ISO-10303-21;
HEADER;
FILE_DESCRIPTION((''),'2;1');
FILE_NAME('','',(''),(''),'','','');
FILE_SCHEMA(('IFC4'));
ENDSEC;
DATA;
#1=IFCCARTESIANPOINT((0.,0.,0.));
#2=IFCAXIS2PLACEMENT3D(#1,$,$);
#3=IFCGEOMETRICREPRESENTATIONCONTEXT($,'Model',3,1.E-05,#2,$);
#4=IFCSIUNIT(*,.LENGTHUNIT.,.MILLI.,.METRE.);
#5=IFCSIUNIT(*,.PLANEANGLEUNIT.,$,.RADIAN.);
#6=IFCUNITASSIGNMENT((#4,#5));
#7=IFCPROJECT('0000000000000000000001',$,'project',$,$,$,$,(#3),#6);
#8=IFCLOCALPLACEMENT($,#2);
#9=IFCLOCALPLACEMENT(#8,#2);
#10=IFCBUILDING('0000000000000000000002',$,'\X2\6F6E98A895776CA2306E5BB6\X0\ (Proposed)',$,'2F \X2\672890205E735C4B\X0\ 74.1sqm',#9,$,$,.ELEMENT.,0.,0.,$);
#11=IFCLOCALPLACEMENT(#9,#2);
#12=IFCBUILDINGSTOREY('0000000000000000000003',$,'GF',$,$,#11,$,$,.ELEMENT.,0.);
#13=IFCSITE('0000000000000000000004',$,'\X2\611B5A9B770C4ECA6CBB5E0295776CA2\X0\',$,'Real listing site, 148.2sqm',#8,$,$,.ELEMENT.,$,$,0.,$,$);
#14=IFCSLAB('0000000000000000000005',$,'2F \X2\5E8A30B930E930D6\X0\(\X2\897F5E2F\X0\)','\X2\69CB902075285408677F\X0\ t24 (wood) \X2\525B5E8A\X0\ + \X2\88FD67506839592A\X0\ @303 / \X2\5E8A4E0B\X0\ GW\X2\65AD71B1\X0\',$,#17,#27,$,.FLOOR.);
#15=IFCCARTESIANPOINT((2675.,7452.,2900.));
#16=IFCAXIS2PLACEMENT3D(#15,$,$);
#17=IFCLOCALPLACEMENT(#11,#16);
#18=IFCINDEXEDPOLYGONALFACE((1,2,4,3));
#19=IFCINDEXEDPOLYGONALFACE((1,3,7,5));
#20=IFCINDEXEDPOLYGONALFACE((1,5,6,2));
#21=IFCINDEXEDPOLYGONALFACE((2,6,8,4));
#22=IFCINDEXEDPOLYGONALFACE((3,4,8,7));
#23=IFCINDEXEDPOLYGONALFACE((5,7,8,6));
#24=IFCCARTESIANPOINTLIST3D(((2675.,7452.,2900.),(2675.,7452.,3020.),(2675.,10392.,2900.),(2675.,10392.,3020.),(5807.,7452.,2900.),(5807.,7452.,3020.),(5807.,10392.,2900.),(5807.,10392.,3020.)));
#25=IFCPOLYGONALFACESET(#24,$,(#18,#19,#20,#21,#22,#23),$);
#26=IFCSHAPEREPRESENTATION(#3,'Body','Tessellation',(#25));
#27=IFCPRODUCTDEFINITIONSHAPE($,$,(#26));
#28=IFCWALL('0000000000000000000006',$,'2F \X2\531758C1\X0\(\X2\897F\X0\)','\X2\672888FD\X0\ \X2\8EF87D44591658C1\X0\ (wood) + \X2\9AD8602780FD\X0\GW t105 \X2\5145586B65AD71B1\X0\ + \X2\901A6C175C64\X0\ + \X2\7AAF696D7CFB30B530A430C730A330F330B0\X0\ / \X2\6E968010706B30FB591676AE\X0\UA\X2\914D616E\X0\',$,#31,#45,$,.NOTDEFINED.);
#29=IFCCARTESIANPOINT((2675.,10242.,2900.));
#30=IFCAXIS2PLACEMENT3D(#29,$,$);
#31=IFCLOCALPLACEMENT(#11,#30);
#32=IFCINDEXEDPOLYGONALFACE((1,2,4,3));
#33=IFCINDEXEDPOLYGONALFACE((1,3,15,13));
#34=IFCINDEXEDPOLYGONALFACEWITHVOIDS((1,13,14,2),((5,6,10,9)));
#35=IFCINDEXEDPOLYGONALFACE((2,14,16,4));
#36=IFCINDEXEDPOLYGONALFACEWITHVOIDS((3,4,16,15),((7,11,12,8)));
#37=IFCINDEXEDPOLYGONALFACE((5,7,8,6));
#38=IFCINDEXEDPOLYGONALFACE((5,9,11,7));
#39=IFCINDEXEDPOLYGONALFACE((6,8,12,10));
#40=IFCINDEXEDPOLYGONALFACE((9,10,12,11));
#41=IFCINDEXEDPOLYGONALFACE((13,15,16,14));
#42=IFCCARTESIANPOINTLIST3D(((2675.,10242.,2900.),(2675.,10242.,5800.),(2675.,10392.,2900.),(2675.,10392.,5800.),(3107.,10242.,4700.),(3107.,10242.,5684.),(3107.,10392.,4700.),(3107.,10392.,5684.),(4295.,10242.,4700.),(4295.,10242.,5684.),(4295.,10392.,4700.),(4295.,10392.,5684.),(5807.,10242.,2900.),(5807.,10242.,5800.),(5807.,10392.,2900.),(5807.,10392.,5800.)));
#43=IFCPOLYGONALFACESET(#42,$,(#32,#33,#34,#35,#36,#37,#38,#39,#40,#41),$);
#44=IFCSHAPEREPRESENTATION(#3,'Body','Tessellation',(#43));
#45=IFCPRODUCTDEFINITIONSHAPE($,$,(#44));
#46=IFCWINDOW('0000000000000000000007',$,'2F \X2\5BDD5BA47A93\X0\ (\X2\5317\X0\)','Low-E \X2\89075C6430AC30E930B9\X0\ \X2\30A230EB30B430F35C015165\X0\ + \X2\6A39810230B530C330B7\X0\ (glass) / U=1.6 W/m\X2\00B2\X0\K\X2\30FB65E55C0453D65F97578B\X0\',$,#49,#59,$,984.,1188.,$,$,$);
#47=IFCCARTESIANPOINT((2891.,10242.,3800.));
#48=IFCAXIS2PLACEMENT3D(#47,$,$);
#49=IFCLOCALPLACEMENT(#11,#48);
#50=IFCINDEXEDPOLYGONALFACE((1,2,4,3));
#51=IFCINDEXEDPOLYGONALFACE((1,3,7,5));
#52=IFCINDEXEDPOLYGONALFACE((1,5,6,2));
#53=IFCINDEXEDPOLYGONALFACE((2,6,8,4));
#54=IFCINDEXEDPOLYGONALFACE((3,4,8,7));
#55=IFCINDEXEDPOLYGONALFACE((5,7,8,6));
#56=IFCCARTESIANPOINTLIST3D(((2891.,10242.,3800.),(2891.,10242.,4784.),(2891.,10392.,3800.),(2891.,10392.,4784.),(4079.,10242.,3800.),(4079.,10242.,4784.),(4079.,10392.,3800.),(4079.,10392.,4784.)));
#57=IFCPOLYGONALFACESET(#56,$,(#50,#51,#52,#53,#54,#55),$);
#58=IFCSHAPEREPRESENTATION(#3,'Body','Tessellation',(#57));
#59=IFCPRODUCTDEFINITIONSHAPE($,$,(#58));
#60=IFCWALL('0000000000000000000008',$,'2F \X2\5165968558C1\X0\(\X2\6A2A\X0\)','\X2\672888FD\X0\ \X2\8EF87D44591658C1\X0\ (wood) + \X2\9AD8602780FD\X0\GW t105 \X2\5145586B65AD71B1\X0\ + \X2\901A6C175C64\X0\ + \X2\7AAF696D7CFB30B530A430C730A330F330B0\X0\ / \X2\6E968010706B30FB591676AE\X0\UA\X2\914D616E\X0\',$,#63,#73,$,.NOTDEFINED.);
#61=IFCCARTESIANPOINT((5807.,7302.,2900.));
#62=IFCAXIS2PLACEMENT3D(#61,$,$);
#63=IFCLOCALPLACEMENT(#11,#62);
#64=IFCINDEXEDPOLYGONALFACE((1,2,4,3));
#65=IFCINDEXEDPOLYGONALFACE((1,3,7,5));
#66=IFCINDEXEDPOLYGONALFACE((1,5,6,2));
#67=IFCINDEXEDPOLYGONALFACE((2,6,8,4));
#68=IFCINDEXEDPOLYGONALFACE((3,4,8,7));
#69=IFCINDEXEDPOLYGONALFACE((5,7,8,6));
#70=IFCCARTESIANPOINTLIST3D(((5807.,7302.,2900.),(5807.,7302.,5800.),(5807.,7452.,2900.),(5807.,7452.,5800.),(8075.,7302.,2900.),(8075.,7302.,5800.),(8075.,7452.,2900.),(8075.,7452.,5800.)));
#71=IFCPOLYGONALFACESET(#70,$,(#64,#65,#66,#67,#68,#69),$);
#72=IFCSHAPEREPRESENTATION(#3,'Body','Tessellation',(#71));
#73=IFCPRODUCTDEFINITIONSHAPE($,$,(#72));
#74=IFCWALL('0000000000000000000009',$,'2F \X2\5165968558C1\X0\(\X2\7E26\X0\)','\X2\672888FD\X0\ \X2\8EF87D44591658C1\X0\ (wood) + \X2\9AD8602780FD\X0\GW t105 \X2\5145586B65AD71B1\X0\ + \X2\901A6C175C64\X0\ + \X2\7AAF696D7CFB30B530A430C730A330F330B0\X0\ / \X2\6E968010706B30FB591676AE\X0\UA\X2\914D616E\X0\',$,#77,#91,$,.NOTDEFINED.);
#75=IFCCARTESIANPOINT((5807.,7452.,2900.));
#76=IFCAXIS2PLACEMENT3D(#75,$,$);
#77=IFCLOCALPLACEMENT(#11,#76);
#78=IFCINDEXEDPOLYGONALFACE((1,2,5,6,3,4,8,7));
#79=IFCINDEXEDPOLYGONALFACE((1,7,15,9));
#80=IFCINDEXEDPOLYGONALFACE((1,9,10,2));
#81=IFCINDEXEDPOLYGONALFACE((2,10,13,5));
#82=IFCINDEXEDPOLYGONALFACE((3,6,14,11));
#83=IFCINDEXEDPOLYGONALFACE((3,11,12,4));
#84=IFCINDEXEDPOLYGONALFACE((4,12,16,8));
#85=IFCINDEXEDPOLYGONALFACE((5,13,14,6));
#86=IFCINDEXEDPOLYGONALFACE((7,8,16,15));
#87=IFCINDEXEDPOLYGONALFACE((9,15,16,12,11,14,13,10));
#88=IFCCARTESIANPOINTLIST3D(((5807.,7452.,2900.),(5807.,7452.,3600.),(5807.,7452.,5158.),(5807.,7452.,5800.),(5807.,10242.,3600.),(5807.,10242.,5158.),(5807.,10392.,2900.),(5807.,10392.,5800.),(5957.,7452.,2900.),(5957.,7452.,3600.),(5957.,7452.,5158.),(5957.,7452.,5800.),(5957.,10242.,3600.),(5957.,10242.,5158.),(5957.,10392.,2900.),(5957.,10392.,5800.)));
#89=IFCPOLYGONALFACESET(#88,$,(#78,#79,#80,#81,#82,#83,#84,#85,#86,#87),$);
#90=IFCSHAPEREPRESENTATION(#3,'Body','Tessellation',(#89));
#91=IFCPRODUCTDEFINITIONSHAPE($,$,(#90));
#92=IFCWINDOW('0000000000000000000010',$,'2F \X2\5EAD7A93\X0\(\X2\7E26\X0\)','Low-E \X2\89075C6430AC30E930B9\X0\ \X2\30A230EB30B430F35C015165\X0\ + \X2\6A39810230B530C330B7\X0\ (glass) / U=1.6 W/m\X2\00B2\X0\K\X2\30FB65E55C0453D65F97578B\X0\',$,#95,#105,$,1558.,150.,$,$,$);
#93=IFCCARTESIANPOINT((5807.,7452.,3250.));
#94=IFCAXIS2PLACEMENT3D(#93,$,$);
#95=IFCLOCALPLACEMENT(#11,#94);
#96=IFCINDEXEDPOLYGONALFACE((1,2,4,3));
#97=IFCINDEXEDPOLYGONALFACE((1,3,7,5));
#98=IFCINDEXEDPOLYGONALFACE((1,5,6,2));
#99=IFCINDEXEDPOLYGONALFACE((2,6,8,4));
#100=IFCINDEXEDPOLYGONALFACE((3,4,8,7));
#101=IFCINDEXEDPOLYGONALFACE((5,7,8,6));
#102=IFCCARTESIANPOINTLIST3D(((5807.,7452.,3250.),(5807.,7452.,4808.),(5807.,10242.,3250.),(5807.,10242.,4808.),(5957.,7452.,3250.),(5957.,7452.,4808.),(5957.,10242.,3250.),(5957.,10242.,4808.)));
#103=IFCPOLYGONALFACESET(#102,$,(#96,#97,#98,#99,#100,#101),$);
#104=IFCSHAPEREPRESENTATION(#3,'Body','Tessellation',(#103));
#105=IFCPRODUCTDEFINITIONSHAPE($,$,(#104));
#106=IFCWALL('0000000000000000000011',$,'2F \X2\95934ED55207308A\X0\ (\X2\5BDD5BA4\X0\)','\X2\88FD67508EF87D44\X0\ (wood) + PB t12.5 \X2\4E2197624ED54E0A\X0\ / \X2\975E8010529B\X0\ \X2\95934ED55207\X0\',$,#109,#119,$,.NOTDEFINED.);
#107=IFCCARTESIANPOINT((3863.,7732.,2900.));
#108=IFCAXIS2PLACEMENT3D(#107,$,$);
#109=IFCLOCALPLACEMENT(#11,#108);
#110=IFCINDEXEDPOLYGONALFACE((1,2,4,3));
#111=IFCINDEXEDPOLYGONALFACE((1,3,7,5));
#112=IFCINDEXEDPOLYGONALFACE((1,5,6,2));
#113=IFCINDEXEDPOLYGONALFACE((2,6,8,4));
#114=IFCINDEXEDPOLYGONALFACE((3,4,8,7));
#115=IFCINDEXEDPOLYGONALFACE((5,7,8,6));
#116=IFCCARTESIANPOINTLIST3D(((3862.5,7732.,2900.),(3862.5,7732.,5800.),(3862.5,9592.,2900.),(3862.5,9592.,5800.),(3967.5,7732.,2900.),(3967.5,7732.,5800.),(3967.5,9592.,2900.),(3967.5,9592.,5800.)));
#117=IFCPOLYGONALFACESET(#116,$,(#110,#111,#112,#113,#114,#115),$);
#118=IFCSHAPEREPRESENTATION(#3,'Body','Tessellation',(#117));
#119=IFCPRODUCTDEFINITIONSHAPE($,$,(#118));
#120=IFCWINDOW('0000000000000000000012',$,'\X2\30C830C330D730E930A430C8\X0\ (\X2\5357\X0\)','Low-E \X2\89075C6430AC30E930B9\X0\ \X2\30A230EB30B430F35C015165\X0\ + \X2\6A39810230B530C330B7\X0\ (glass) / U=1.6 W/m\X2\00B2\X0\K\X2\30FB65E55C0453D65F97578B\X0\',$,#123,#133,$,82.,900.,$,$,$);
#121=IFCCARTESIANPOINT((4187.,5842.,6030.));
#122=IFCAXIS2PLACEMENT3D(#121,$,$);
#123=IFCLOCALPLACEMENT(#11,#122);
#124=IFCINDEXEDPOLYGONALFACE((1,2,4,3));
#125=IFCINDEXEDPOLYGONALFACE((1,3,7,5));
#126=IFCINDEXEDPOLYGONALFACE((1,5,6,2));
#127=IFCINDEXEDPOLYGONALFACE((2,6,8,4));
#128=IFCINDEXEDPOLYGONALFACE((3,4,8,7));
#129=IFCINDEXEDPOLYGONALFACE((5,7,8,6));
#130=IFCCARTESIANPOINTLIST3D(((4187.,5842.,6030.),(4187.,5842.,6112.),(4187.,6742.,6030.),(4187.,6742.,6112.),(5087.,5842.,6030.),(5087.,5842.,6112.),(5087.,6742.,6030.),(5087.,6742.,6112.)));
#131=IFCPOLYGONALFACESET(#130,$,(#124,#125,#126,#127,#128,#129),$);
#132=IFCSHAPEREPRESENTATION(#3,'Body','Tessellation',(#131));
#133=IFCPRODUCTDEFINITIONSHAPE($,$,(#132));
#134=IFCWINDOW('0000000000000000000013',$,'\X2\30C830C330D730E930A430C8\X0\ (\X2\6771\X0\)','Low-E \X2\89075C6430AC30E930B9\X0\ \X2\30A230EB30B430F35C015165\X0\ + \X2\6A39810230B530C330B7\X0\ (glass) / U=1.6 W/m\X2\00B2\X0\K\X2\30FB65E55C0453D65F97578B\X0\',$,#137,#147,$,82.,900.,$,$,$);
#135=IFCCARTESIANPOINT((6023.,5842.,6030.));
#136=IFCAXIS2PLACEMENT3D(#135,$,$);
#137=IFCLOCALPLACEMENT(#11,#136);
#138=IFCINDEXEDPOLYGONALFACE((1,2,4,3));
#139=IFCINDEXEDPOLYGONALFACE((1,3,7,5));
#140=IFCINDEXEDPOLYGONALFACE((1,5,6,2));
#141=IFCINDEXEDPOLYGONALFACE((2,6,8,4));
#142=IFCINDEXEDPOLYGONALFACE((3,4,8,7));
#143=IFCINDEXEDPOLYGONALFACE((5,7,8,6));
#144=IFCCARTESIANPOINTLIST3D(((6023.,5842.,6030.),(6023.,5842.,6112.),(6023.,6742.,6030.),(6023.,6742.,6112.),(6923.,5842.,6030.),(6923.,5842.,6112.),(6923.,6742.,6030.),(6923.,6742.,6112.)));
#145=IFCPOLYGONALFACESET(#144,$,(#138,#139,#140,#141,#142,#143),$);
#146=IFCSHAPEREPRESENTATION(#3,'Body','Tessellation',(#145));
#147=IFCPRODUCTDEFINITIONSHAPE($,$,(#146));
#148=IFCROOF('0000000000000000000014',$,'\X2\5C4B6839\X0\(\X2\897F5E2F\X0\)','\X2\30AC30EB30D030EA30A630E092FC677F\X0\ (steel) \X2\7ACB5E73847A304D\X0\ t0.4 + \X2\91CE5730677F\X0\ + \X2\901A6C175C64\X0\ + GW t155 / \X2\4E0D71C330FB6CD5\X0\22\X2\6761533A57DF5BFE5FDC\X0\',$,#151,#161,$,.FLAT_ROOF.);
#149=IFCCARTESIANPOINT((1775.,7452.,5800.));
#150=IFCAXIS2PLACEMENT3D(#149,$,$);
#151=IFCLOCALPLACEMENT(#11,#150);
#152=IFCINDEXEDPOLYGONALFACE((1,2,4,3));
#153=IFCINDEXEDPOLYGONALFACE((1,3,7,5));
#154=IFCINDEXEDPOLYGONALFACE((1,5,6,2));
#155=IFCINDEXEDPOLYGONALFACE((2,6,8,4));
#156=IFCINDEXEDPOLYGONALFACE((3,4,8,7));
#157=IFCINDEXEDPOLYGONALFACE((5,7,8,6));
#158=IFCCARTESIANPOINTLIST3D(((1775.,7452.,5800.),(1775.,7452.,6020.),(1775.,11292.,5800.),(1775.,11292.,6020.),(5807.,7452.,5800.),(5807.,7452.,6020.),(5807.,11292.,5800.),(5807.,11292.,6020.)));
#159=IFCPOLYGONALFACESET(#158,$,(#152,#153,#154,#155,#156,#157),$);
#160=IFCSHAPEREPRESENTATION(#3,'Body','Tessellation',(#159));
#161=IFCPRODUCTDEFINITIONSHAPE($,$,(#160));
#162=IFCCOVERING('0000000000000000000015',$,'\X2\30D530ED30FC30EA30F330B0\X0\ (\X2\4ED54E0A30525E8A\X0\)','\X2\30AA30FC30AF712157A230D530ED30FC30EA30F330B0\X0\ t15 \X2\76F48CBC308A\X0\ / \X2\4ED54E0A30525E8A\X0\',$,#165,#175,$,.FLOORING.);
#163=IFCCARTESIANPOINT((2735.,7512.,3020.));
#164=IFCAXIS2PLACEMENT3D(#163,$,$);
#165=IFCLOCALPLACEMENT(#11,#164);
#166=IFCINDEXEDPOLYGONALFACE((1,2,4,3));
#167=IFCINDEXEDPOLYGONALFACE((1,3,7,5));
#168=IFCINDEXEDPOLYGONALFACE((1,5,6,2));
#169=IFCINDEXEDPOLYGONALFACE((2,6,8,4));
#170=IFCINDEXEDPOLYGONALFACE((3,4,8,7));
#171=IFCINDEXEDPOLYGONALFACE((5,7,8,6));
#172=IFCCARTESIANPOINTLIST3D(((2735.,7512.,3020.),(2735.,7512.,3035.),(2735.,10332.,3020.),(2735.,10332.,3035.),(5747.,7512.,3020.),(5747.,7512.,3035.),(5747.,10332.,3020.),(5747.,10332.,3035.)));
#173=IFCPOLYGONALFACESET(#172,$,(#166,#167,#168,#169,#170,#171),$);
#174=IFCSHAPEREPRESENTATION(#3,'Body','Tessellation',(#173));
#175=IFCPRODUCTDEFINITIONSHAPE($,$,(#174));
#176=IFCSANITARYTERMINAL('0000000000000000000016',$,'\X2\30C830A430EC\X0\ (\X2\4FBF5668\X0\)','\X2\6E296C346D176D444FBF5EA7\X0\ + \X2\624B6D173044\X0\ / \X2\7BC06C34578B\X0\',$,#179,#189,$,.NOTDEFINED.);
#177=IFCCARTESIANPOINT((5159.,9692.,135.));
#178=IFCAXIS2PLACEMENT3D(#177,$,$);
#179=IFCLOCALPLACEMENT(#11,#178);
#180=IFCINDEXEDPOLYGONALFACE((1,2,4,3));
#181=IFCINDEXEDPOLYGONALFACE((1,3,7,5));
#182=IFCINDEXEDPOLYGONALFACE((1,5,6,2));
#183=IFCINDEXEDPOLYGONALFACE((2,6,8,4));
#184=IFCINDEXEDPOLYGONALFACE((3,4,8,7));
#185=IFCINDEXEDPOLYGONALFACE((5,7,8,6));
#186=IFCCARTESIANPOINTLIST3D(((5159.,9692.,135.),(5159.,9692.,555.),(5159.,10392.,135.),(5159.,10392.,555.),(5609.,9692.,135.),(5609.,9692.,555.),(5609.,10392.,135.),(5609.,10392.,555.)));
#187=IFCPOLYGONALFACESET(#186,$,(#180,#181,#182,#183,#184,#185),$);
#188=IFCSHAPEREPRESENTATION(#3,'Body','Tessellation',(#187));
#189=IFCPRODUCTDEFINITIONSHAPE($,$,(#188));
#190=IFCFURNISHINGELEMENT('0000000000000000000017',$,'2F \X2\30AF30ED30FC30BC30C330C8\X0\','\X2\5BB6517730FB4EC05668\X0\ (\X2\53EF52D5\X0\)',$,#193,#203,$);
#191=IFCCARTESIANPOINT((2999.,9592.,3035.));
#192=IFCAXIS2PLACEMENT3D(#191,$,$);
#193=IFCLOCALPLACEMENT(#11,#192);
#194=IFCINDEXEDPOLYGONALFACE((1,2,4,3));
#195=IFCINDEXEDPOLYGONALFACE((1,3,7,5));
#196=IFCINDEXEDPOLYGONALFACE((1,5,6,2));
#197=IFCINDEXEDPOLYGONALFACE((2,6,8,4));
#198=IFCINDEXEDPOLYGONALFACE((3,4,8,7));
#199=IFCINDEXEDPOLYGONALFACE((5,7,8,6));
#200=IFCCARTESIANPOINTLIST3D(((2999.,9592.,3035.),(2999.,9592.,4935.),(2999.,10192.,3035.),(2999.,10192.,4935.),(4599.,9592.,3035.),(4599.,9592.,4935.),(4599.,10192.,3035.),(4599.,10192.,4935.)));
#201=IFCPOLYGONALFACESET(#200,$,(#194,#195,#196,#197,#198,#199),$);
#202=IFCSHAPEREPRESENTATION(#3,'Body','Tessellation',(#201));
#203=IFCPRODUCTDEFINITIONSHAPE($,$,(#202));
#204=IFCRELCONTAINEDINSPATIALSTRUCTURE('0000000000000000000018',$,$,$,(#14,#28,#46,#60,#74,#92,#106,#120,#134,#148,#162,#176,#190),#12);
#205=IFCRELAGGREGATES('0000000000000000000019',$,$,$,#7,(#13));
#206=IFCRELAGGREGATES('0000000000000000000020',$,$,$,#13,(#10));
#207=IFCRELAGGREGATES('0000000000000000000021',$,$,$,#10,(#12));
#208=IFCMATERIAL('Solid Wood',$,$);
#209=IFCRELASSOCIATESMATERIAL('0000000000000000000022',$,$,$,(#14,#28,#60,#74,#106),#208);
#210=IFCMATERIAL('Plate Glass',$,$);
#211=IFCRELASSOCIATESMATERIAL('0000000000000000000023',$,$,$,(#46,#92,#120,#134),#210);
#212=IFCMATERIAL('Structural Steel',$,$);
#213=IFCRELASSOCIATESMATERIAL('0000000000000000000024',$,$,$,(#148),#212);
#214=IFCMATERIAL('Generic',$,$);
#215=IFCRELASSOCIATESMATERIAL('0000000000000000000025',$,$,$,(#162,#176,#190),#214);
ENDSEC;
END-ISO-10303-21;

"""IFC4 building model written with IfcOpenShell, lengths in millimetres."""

from ifc_helpers import new_model, si_unit, frame, frame_2d, origin, place, context, project, spatial, rectangle, extrude, material, element, fill, save


model = new_model("IFC4")

# Units and contexts
model_context = context("Model", 3, precision=1e-05, world=origin())
ifc_project = project(units=[si_unit("LENGTHUNIT", "METRE", prefix="MILLI"), si_unit("PLANEANGLEUNIT", "RADIAN")], contexts=[model_context])

# Site, building, storey
site_placement = place(None, origin())
site = spatial("IfcSite", under=ifc_project, at=site_placement, Name="愛媛県今治市長沢", ObjectType="Real listing site, 148.2sqm", CompositionType="ELEMENT", RefElevation=0.0)
building_placement = place(site_placement, origin())
building = spatial("IfcBuilding", under=site, at=building_placement, Name="潮風長沢の家 (Proposed)", ObjectType="2F 木造平屋 74.1sqm", CompositionType="ELEMENT", ElevationOfRefHeight=0.0, ElevationOfTerrain=0.0)
storey_placement = place(building_placement, origin())
storey = spatial("IfcBuildingStorey", under=building, at=storey_placement, Name="GF", CompositionType="ELEMENT", Elevation=0.0)

# Slab
ifc_material_1 = material(Name="Solid Wood")
slab_placement = place(storey_placement, frame((2675.0, 7452.0, 2900.0)))
element("IfcSlab", 1, at=slab_placement, inside=storey, material=ifc_material_1, Name="2F 床スラブ(西帯)", Description="構造用合板 t24 (wood) 剛床 + 製材根太 @303 / 床下 GW断熱", PredefinedType="FLOOR", context=model_context, shape_type="SweptSolid", body=[
    extrude(rectangle(XDim=3132.0, YDim=2940.0, at=frame_2d((1566.0, 1470.0))), frame((2675.0, 7452.0, 2900.0)), (0.0, 0.0, 1.0), 120.0),
])

# Wall, opening, window
wall_1_placement = place(storey_placement, frame((2675.0, 10242.0, 2900.0)))
wall_1 = element("IfcWall", 2, at=wall_1_placement, inside=storey, material=ifc_material_1, Name="2F 北壁(西)", Description="木製 軸組外壁 (wood) + 高性能GW t105 充填断熱 + 通気層 + 窯業系サイディング / 準耐火・外皮UA配慮", PredefinedType="NOTDEFINED", context=model_context, shape_type="SweptSolid", body=[
    extrude(rectangle(XDim=3132.0, YDim=150.0, at=frame_2d((1566.0, 75.0))), frame((2675.0, 10242.0, 2900.0)), (0.0, 0.0, 1.0), 2900.0),
])
opening_1_placement = place(storey_placement, frame((2891.0, 10242.0, 3800.0)))
opening_1 = element("IfcOpeningElement", 3, at=opening_1_placement, cuts=wall_1, PredefinedType="NOTDEFINED", context=model_context, shape_type="SweptSolid", body=[
    extrude(rectangle(XDim=1188.0, YDim=150.0, at=frame_2d((594.0, 75.0))), frame((2891.0, 10242.0, 3800.0)), (0.0, 0.0, 1.0), 984.0),
])
ifc_material_2 = material(Name="Plate Glass")
window_1_placement = place(storey_placement, frame((2891.0, 10242.0, 3800.0)))
window_1 = element("IfcWindow", 4, at=window_1_placement, inside=storey, material=ifc_material_2, Name="2F 寝室窓 (北)", Description="Low-E 複層ガラス アルゴン封入 + 樹脂サッシ (glass) / U=1.6 W/m²K・日射取得型", OverallHeight=984.0, OverallWidth=1188.0, context=model_context, shape_type="SweptSolid", body=[
    extrude(rectangle(XDim=1188.0, YDim=150.0, at=frame_2d((594.0, 75.0))), frame((2891.0, 10242.0, 3800.0)), (0.0, 0.0, 1.0), 984.0),
])
fill(opening_1, window_1)

# Wall
wall_2_placement = place(storey_placement, frame((5807.0, 7302.0, 2900.0)))
element("IfcWall", 5, at=wall_2_placement, inside=storey, material=ifc_material_1, Name="2F 入隅壁(横)", Description="木製 軸組外壁 (wood) + 高性能GW t105 充填断熱 + 通気層 + 窯業系サイディング / 準耐火・外皮UA配慮", PredefinedType="NOTDEFINED", context=model_context, shape_type="SweptSolid", body=[
    extrude(rectangle(XDim=2268.0, YDim=150.0, at=frame_2d((1134.0, 75.0))), frame((5807.0, 7302.0, 2900.0)), (0.0, 0.0, 1.0), 2900.0),
])

# Wall, opening, window
wall_3_placement = place(storey_placement, frame((5807.0, 7452.0, 2900.0)))
wall_3 = element("IfcWall", 6, at=wall_3_placement, inside=storey, material=ifc_material_1, Name="2F 入隅壁(縦)", Description="木製 軸組外壁 (wood) + 高性能GW t105 充填断熱 + 通気層 + 窯業系サイディング / 準耐火・外皮UA配慮", PredefinedType="NOTDEFINED", context=model_context, shape_type="SweptSolid", body=[
    extrude(rectangle(XDim=150.0, YDim=2940.0, at=frame_2d((75.0, 1470.0))), frame((5807.0, 7452.0, 2900.0)), (0.0, 0.0, 1.0), 2900.0),
])
opening_2_placement = place(storey_placement, frame((5807.0, 7452.0, 3250.0)))
opening_2 = element("IfcOpeningElement", 7, at=opening_2_placement, cuts=wall_3, PredefinedType="NOTDEFINED", context=model_context, shape_type="SweptSolid", body=[
    extrude(rectangle(XDim=150.0, YDim=2790.0, at=frame_2d((75.0, 1395.0))), frame((5807.0, 7452.0, 3250.0)), (0.0, 0.0, 1.0), 1558.0),
])
window_2_placement = place(storey_placement, frame((5807.0, 7452.0, 3250.0)))
window_2 = element("IfcWindow", 8, at=window_2_placement, inside=storey, material=ifc_material_2, Name="2F 庭窓(縦)", Description="Low-E 複層ガラス アルゴン封入 + 樹脂サッシ (glass) / U=1.6 W/m²K・日射取得型", OverallHeight=1558.0, OverallWidth=150.0, context=model_context, shape_type="SweptSolid", body=[
    extrude(rectangle(XDim=150.0, YDim=2790.0, at=frame_2d((75.0, 1395.0))), frame((5807.0, 7452.0, 3250.0)), (0.0, 0.0, 1.0), 1558.0),
])
fill(opening_2, window_2)

# Wall
wall_4_placement = place(storey_placement, frame((3863.0, 7732.0, 2900.0)))
element("IfcWall", 9, at=wall_4_placement, inside=storey, material=ifc_material_1, Name="2F 間仕切り (寝室)", Description="製材軸組 (wood) + PB t12.5 両面仕上 / 非耐力 間仕切", PredefinedType="NOTDEFINED", context=model_context, shape_type="SweptSolid", body=[
    extrude(rectangle(XDim=105.0, YDim=1860.0, at=frame_2d((52.0, 930.0))), frame((3863.0, 7732.0, 2900.0)), (0.0, 0.0, 1.0), 2900.0),
])

# Windows
window_3_placement = place(storey_placement, frame((4187.0, 5842.0, 6030.0)))
element("IfcWindow", 10, at=window_3_placement, inside=storey, material=ifc_material_2, Name="トップライト (南)", Description="Low-E 複層ガラス アルゴン封入 + 樹脂サッシ (glass) / U=1.6 W/m²K・日射取得型", OverallHeight=82.0, OverallWidth=900.0, context=model_context, shape_type="SweptSolid", body=[
    extrude(rectangle(XDim=900.0, YDim=900.0, at=frame_2d((450.0, 450.0))), frame((4187.0, 5842.0, 6030.0)), (0.0, 0.0, 1.0), 82.0),
])
window_4_placement = place(storey_placement, frame((6023.0, 5842.0, 6030.0)))
element("IfcWindow", 11, at=window_4_placement, inside=storey, material=ifc_material_2, Name="トップライト (東)", Description="Low-E 複層ガラス アルゴン封入 + 樹脂サッシ (glass) / U=1.6 W/m²K・日射取得型", OverallHeight=82.0, OverallWidth=900.0, context=model_context, shape_type="SweptSolid", body=[
    extrude(rectangle(XDim=900.0, YDim=900.0, at=frame_2d((450.0, 450.0))), frame((6023.0, 5842.0, 6030.0)), (0.0, 0.0, 1.0), 82.0),
])

# Roof
ifc_material_3 = material(Name="Structural Steel")
for number, where, name in (
    (12, (1775.0, 7452.0, 5800.0), "屋根(西帯)"),
):
    element("IfcRoof", number, at=place(storey_placement, frame(where)), inside=storey, material=ifc_material_3, Name=name, Description="ガルバリウム鋼板 (steel) 立平葺き t0.4 + 野地板 + 通気層 + GW t155 / 不燃・法22条区域対応", PredefinedType="FLAT_ROOF", context=model_context, shape_type="SweptSolid", body=[
        extrude(rectangle(XDim=4032.0, YDim=3840.0, at=frame_2d((2016.0, 1920.0))), frame((1775.0, 7452.0, 5800.0)), (0.0, 0.0, 1.0), 220.0),
    ])

# Covering
ifc_material_4 = material(Name="Generic")
covering_placement = place(storey_placement, frame((2735.0, 7512.0, 3020.0)))
element("IfcCovering", 13, at=covering_placement, inside=storey, material=ifc_material_4, Name="フローリング (仕上げ床)", Description="オーク無垢フローリング t15 直貼り / 仕上げ床", PredefinedType="FLOORING", context=model_context, shape_type="SweptSolid", body=[
    extrude(rectangle(XDim=3012.0, YDim=2820.0, at=frame_2d((1506.0, 1410.0))), frame((2735.0, 7512.0, 3020.0)), (0.0, 0.0, 1.0), 15.0),
])

# Sanitary terminal
sanitary_terminal_placement = place(storey_placement, frame((5159.0, 9692.0, 135.0)))
element("IfcSanitaryTerminal", 14, at=sanitary_terminal_placement, inside=storey, material=ifc_material_4, Name="トイレ (便器)", Description="温水洗浄便座 + 手洗い / 節水型", PredefinedType="NOTDEFINED", context=model_context, shape_type="SweptSolid", body=[
    extrude(rectangle(XDim=450.0, YDim=700.0, at=frame_2d((225.0, 350.0))), frame((5159.0, 9692.0, 135.0)), (0.0, 0.0, 1.0), 420.0),
])

# Furnishing element
furnishing_1_placement = place(storey_placement, frame((2999.0, 9592.0, 3035.0)))
element("IfcFurnishingElement", 15, at=furnishing_1_placement, inside=storey, material=ifc_material_4, Name="2F クローゼット", Description="家具・什器 (可動)", context=model_context, shape_type="SweptSolid", body=[
    extrude(rectangle(XDim=1600.0, YDim=600.0, at=frame_2d((800.0, 300.0))), frame((2999.0, 9592.0, 3035.0)), (0.0, 0.0, 1.0), 1900.0),
])

save(model, "model.ifc")
